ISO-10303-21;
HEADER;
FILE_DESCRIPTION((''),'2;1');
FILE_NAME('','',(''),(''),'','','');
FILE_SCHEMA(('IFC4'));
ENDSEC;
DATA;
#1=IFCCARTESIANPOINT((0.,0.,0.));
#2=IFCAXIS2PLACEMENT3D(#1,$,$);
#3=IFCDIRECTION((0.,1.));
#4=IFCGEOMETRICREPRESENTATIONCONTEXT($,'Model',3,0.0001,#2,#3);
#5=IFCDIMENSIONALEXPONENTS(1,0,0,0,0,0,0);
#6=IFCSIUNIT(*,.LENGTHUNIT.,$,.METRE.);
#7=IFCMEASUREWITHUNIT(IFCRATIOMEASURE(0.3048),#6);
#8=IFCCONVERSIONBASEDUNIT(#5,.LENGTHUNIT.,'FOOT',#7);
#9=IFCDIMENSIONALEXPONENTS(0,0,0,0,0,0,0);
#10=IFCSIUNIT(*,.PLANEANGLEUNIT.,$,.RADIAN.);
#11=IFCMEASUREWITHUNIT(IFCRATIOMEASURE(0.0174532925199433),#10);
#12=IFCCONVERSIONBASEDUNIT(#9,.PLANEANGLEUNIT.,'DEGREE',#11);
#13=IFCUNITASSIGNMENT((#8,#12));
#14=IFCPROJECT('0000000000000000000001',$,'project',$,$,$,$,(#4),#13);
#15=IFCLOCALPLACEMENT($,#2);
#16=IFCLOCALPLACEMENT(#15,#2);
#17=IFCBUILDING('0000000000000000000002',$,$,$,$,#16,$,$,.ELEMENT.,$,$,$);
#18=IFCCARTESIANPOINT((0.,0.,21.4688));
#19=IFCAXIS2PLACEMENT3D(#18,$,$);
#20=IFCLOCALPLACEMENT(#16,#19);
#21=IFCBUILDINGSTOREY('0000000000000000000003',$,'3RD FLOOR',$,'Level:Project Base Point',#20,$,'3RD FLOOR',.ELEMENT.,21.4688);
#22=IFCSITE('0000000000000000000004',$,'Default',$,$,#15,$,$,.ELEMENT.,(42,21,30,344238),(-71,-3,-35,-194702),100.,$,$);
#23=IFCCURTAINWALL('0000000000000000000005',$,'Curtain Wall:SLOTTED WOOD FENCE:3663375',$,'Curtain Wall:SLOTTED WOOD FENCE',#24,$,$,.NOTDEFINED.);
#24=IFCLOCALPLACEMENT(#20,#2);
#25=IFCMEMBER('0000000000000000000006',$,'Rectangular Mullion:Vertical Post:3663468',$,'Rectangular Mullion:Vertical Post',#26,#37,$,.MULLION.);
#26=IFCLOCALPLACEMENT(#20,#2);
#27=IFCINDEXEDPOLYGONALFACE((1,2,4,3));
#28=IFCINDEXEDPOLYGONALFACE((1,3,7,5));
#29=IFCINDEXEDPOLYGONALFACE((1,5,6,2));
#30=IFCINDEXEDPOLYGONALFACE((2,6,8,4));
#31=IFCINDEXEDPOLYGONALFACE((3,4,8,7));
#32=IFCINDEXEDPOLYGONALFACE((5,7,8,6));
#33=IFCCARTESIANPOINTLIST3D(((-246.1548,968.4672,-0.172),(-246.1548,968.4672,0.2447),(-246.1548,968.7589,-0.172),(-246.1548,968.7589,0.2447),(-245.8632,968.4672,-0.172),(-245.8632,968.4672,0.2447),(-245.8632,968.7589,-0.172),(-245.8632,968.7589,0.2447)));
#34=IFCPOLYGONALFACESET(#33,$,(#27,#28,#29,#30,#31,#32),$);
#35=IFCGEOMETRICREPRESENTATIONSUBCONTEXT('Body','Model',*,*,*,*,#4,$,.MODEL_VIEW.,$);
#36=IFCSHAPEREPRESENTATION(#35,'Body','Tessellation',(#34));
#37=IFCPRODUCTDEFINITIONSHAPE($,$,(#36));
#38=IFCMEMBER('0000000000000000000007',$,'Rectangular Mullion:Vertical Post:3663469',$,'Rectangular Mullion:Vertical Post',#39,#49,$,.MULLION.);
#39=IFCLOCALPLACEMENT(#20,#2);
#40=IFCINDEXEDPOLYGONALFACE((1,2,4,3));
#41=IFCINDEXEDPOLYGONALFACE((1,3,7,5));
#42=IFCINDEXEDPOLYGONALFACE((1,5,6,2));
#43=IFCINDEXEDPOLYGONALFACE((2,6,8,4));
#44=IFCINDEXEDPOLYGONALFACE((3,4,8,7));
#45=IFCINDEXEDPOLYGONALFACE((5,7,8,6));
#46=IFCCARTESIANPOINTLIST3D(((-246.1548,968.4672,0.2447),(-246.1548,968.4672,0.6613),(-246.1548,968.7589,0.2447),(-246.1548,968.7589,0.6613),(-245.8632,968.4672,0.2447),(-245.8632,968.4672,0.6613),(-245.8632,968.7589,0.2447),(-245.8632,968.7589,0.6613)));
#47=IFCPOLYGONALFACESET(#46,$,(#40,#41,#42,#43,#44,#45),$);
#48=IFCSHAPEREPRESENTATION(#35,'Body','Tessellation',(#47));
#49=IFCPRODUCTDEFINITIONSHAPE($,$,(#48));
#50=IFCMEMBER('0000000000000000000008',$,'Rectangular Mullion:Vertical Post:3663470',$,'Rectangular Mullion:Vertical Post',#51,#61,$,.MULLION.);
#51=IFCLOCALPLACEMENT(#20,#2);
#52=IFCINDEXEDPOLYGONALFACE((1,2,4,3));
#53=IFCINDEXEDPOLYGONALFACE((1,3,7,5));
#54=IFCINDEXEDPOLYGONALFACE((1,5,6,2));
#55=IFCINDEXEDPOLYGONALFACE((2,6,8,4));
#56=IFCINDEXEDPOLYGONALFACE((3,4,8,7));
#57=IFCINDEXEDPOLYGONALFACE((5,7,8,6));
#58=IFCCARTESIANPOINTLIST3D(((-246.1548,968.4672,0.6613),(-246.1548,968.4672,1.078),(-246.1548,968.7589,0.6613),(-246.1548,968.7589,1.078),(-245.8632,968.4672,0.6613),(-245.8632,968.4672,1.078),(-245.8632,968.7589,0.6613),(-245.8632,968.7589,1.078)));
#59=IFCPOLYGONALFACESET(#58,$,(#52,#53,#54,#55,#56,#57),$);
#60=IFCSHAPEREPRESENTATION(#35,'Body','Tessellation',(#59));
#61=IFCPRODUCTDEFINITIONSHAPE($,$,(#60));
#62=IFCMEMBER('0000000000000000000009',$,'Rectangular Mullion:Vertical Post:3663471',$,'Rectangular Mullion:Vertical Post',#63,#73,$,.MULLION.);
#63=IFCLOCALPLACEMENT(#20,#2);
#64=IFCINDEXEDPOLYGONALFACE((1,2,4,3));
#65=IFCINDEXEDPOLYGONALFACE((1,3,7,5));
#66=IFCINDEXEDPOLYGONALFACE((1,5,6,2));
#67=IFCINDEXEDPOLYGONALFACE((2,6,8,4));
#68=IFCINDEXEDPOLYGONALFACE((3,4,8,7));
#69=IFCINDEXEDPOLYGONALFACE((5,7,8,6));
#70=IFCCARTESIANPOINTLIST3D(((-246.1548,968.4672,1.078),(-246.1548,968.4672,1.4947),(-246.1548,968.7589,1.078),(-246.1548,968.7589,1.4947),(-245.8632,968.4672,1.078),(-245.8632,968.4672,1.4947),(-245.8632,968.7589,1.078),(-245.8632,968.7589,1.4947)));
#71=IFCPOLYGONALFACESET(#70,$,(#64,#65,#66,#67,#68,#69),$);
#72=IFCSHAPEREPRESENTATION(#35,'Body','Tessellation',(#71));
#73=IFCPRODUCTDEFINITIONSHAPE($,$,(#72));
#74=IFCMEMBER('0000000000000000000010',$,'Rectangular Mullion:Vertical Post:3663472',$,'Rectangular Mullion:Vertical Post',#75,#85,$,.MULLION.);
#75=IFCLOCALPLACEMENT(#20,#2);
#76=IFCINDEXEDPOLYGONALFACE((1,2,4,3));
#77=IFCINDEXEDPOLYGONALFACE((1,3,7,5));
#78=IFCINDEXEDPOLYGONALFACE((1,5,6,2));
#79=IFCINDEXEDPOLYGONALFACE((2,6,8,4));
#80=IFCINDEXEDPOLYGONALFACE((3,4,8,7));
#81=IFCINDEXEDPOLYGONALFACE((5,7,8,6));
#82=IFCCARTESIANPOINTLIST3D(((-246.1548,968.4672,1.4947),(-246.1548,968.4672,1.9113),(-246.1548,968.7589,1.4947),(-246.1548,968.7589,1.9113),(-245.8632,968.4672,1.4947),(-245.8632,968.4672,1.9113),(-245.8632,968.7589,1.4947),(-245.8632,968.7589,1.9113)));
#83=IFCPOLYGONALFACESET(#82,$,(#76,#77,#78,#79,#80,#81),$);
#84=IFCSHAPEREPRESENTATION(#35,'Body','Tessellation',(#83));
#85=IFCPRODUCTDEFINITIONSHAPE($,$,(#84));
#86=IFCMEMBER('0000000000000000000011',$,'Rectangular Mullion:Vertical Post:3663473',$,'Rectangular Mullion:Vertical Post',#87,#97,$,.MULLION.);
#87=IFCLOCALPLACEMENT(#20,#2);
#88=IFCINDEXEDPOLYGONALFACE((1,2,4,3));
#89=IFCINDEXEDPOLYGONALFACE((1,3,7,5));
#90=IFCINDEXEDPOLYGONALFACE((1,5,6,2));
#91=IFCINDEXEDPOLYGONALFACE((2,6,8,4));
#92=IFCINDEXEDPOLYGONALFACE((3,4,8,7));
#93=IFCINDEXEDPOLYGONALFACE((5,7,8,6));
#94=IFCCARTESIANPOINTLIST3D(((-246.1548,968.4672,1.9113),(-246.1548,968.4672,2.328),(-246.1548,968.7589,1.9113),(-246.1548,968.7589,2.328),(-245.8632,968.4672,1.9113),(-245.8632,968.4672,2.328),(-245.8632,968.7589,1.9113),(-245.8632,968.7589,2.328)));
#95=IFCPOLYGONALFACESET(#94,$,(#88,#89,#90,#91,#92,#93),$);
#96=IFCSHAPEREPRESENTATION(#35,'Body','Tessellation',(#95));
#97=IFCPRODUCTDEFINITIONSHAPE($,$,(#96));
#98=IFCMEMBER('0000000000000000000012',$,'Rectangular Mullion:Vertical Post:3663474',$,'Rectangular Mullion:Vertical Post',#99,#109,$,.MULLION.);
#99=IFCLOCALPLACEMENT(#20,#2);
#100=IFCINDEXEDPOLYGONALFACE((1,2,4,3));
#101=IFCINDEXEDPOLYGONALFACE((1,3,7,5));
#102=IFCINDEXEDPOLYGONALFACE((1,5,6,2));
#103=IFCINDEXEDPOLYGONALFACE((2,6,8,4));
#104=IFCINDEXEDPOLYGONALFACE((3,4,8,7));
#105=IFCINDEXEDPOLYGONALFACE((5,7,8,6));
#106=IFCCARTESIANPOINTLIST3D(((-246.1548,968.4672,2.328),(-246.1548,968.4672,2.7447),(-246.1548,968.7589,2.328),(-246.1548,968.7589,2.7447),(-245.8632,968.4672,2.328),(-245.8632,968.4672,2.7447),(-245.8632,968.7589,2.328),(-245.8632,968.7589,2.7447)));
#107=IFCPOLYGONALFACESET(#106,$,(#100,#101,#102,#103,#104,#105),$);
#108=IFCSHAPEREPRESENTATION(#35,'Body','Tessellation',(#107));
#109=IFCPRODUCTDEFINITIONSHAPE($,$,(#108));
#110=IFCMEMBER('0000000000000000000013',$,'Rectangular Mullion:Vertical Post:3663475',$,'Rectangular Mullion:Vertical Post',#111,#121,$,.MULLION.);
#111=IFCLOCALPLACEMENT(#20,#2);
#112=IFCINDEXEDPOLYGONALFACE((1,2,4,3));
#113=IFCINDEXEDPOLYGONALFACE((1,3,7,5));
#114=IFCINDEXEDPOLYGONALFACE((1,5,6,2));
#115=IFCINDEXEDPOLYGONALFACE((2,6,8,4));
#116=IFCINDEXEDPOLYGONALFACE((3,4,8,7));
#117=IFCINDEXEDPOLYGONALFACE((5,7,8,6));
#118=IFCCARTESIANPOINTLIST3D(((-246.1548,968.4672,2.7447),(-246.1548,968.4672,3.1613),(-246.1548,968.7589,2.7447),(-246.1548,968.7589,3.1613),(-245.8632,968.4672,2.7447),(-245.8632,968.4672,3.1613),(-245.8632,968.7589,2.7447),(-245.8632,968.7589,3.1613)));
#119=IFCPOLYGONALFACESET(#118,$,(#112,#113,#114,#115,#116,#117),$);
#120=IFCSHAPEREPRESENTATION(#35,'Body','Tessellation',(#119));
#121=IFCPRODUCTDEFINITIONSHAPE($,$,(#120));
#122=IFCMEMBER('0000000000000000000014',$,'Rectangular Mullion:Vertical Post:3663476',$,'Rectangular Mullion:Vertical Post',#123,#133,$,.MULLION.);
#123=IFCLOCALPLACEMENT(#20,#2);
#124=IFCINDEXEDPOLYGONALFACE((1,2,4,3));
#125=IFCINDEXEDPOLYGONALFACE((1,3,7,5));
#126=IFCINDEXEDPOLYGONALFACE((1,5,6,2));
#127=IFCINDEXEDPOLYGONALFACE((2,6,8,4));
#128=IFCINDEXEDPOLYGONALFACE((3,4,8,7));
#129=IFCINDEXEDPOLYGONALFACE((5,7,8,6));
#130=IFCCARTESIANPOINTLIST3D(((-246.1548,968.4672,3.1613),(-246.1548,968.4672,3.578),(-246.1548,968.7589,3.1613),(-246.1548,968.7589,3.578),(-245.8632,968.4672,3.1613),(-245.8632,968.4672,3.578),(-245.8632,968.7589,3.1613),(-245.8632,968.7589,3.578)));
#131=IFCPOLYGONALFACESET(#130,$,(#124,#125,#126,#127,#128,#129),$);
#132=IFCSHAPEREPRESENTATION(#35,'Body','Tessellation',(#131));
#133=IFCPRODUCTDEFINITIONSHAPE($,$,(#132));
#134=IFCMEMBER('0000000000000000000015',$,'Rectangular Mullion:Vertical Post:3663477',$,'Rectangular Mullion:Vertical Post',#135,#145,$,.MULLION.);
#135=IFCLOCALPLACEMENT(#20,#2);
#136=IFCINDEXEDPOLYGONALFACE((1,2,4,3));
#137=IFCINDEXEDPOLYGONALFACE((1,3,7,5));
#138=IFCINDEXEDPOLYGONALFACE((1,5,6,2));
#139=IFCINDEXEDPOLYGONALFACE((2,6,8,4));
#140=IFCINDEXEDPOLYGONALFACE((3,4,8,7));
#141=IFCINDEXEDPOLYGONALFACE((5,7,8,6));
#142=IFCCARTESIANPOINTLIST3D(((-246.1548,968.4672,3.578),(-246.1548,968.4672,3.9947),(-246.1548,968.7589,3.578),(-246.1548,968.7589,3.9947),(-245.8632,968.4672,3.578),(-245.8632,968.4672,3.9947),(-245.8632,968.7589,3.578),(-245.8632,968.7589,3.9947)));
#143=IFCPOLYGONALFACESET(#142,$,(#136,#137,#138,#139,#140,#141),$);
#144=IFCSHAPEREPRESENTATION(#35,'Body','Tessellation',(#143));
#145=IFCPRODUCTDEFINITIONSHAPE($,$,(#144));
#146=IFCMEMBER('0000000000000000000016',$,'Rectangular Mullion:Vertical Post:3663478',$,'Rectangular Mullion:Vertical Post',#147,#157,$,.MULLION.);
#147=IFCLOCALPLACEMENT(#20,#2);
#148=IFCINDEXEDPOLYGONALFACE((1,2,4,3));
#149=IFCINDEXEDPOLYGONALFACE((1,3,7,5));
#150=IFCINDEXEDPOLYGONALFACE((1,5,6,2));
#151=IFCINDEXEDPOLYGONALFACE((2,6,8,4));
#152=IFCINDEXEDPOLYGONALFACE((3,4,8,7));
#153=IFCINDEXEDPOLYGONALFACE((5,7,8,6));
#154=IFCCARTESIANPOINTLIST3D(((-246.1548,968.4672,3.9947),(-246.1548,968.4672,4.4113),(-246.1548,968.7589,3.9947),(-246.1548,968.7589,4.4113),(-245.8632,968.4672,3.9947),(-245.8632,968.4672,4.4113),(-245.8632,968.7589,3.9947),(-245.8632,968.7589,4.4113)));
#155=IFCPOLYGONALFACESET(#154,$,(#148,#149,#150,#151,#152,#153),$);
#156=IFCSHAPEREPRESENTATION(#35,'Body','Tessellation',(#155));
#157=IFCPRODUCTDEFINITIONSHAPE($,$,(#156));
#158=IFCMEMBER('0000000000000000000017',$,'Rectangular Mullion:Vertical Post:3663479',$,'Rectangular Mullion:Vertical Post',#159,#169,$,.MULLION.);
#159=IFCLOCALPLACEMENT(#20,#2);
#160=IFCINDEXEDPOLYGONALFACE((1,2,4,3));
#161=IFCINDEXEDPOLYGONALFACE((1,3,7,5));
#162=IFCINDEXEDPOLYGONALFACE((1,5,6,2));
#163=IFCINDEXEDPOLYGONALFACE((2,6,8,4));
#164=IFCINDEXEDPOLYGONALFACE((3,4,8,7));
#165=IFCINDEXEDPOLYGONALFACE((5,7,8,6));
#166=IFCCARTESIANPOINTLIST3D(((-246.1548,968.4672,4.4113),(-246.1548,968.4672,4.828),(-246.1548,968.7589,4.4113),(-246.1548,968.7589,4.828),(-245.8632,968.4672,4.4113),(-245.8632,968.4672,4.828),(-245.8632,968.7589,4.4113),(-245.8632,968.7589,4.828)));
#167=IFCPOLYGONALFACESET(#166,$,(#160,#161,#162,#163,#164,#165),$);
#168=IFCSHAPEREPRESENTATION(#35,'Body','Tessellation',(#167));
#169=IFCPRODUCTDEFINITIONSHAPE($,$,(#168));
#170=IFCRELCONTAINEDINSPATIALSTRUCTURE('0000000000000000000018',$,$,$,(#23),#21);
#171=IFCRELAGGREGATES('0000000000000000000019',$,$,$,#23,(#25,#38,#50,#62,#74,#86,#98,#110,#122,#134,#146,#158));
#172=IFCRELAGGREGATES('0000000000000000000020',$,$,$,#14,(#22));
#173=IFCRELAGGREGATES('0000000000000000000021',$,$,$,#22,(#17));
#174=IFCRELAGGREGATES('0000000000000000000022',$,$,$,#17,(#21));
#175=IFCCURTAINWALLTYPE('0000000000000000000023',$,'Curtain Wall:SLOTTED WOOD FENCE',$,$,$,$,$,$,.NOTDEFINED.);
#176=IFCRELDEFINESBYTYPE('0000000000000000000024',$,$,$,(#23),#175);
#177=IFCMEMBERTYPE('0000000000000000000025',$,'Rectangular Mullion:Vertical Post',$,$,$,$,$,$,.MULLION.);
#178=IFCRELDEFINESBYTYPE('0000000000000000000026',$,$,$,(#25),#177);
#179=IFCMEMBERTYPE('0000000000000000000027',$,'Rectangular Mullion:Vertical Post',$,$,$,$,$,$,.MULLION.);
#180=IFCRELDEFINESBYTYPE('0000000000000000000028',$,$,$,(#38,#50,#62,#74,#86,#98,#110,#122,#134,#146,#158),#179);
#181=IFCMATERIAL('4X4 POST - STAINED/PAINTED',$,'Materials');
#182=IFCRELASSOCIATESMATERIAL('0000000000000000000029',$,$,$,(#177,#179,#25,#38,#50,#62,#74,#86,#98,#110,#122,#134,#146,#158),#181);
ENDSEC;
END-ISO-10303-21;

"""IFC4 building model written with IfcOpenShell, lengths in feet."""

from ifc_helpers import new_model, entity, si_unit, converted_unit, direction, frame, origin, origin_2d_with_axis, place, context, subcontext, project, spatial, rectangle, extrude, source, transform, mapped, material, material_profile, profile_set, profile_usage, type_object, type_shapes, element, aggregate, save


model = new_model("IFC4")

# Units and contexts
model_context = context("Model", 3, precision=0.0001, world=origin(), true_north=direction((0.0, 1.0)))
body_context = subcontext(model_context, "Body", "Model", "MODEL_VIEW")
ifc_project = project(units=[converted_unit("LENGTHUNIT", "FOOT", entity("IfcRatioMeasure", 0.3048), si_unit("LENGTHUNIT", "METRE"), dimensions=[1, 0, 0, 0, 0, 0, 0]), converted_unit("PLANEANGLEUNIT", "DEGREE", entity("IfcRatioMeasure", 0.0174532925199433), si_unit("PLANEANGLEUNIT", "RADIAN"), dimensions=[0, 0, 0, 0, 0, 0, 0])], contexts=[model_context])

# Site, building, storey
site_placement = place(None, origin())
site = spatial("IfcSite", under=ifc_project, at=site_placement, Name="Default", CompositionType="ELEMENT", RefLatitude=(42, 21, 30, 344238), RefLongitude=(-71, -3, -35, -194702), RefElevation=100.0)
building_placement = place(site_placement, origin())
building = spatial("IfcBuilding", under=site, at=building_placement, CompositionType="ELEMENT")
storey_placement = place(building_placement, frame((0.0, 0.0, 21.4688)))
storey = spatial("IfcBuildingStorey", under=building, at=storey_placement, Name="3RD FLOOR", ObjectType="Level:Project Base Point", LongName="3RD FLOOR", CompositionType="ELEMENT", Elevation=21.4688)

# Curtain wall, members
curtain_wall_type = type_object("IfcCurtainWallType", Name="Curtain Wall:SLOTTED WOOD FENCE", PredefinedType="NOTDEFINED")
curtain_wall_placement = place(storey_placement, frame((0.0, 0.0, -21.4688)))
curtain_wall = element("IfcCurtainWall", 1, at=curtain_wall_placement, inside=storey, type_object=curtain_wall_type, Name="Curtain Wall:SLOTTED WOOD FENCE:3663375", ObjectType="Curtain Wall:SLOTTED WOOD FENCE", PredefinedType="NOTDEFINED")
ifc_material = material(Name="4X4 POST - STAINED/PAINTED", Category="Materials")
ifc_material_profile = material_profile(ifc_material, rectangle(XDim=0.2917, YDim=0.2917, at=origin_2d_with_axis()), Name="Vertical Post")
ifc_profile_set = profile_set([ifc_material_profile], Name="Vertical Post")
ifc_profile_usage_1 = profile_usage(ifc_profile_set)
member_type_1 = type_object("IfcMemberType", Name="Rectangular Mullion:Vertical Post", PredefinedType="MULLION", material=ifc_profile_set)
shared_shape_1 = source(origin(), body_context, "Body", "SweptSolid", [
    extrude(rectangle(XDim=0.2917, YDim=0.2917, at=origin_2d_with_axis()), frame((-0.1458, 0.2083, -0.4167), z_axis=(0.0, 0.0, 1.0), x_axis=(0.0, -1.0, 0.0)), (0.0, 0.0, 1.0), 0.4167),
])
type_shapes(member_type_1, [shared_shape_1])
member_1_placement = place(storey_placement, frame((-245.8007, 968.7589, 0.2447), z_axis=(0.0, 0.0, 1.0), x_axis=(0.0, 1.0, 0.0)))
member_1 = element("IfcMember", 2, at=member_1_placement, type_object=member_type_1, material=ifc_profile_usage_1, Name="Rectangular Mullion:Vertical Post:3663468", ObjectType="Rectangular Mullion:Vertical Post", PredefinedType="MULLION", context=body_context, shape_type="MappedRepresentation", body=[
    mapped(shared_shape_1, transform((0.0, 0.0, 0.0), scale=1.0)),
])
ifc_profile_usage_2 = profile_usage(ifc_profile_set)
member_type_2 = type_object("IfcMemberType", Name="Rectangular Mullion:Vertical Post", PredefinedType="MULLION", material=ifc_profile_set)
shared_shape_2 = source(origin(), body_context, "Body", "SweptSolid", [
    extrude(rectangle(XDim=0.2917, YDim=0.2917, at=origin_2d_with_axis()), frame((-0.1458, 0.2083, -0.4167), z_axis=(0.0, 0.0, 1.0), x_axis=(0.0, -1.0, 0.0)), (0.0, 0.0, 1.0), 0.4167),
])
type_shapes(member_type_2, [shared_shape_2])
member_2_placement = place(storey_placement, frame((-245.8007, 968.7589, 0.6613), z_axis=(0.0, 0.0, 1.0), x_axis=(0.0, 1.0, 0.0)))
member_2 = element("IfcMember", 3, at=member_2_placement, type_object=member_type_2, material=ifc_profile_usage_2, Name="Rectangular Mullion:Vertical Post:3663469", ObjectType="Rectangular Mullion:Vertical Post", PredefinedType="MULLION", context=body_context, shape_type="MappedRepresentation", body=[
    mapped(shared_shape_2, transform((0.0, 0.0, 0.0), scale=1.0)),
])
ifc_profile_usage_3 = profile_usage(ifc_profile_set)
member_3_placement = place(storey_placement, frame((-245.8007, 968.7589, 1.078), z_axis=(0.0, 0.0, 1.0), x_axis=(0.0, 1.0, 0.0)))
member_3 = element("IfcMember", 4, at=member_3_placement, type_object=member_type_2, material=ifc_profile_usage_3, Name="Rectangular Mullion:Vertical Post:3663470", ObjectType="Rectangular Mullion:Vertical Post", PredefinedType="MULLION", context=body_context, shape_type="MappedRepresentation", body=[
    mapped(shared_shape_2, transform((0.0, 0.0, 0.0), scale=1.0)),
])
ifc_profile_usage_4 = profile_usage(ifc_profile_set)
member_4_placement = place(storey_placement, frame((-245.8007, 968.7589, 1.4947), z_axis=(0.0, 0.0, 1.0), x_axis=(0.0, 1.0, 0.0)))
member_4 = element("IfcMember", 5, at=member_4_placement, type_object=member_type_2, material=ifc_profile_usage_4, Name="Rectangular Mullion:Vertical Post:3663471", ObjectType="Rectangular Mullion:Vertical Post", PredefinedType="MULLION", context=body_context, shape_type="MappedRepresentation", body=[
    mapped(shared_shape_2, transform((0.0, 0.0, 0.0), scale=1.0)),
])
ifc_profile_usage_5 = profile_usage(ifc_profile_set)
member_5_placement = place(storey_placement, frame((-245.8007, 968.7589, 1.9113), z_axis=(0.0, 0.0, 1.0), x_axis=(0.0, 1.0, 0.0)))
member_5 = element("IfcMember", 6, at=member_5_placement, type_object=member_type_2, material=ifc_profile_usage_5, Name="Rectangular Mullion:Vertical Post:3663472", ObjectType="Rectangular Mullion:Vertical Post", PredefinedType="MULLION", context=body_context, shape_type="MappedRepresentation", body=[
    mapped(shared_shape_2, transform((0.0, 0.0, 0.0), scale=1.0)),
])
ifc_profile_usage_6 = profile_usage(ifc_profile_set)
member_6_placement = place(storey_placement, frame((-245.8007, 968.7589, 2.328), z_axis=(0.0, 0.0, 1.0), x_axis=(0.0, 1.0, 0.0)))
member_6 = element("IfcMember", 7, at=member_6_placement, type_object=member_type_2, material=ifc_profile_usage_6, Name="Rectangular Mullion:Vertical Post:3663473", ObjectType="Rectangular Mullion:Vertical Post", PredefinedType="MULLION", context=body_context, shape_type="MappedRepresentation", body=[
    mapped(shared_shape_2, transform((0.0, 0.0, 0.0), scale=1.0)),
])
ifc_profile_usage_7 = profile_usage(ifc_profile_set)
member_7_placement = place(storey_placement, frame((-245.8007, 968.7589, 2.7447), z_axis=(0.0, 0.0, 1.0), x_axis=(0.0, 1.0, 0.0)))
member_7 = element("IfcMember", 8, at=member_7_placement, type_object=member_type_2, material=ifc_profile_usage_7, Name="Rectangular Mullion:Vertical Post:3663474", ObjectType="Rectangular Mullion:Vertical Post", PredefinedType="MULLION", context=body_context, shape_type="MappedRepresentation", body=[
    mapped(shared_shape_2, transform((0.0, 0.0, 0.0), scale=1.0)),
])
ifc_profile_usage_8 = profile_usage(ifc_profile_set)
member_8_placement = place(storey_placement, frame((-245.8007, 968.7589, 3.1613), z_axis=(0.0, 0.0, 1.0), x_axis=(0.0, 1.0, 0.0)))
member_8 = element("IfcMember", 9, at=member_8_placement, type_object=member_type_2, material=ifc_profile_usage_8, Name="Rectangular Mullion:Vertical Post:3663475", ObjectType="Rectangular Mullion:Vertical Post", PredefinedType="MULLION", context=body_context, shape_type="MappedRepresentation", body=[
    mapped(shared_shape_2, transform((0.0, 0.0, 0.0), scale=1.0)),
])
ifc_profile_usage_9 = profile_usage(ifc_profile_set)
member_9_placement = place(storey_placement, frame((-245.8007, 968.7589, 3.578), z_axis=(0.0, 0.0, 1.0), x_axis=(0.0, 1.0, 0.0)))
member_9 = element("IfcMember", 10, at=member_9_placement, type_object=member_type_2, material=ifc_profile_usage_9, Name="Rectangular Mullion:Vertical Post:3663476", ObjectType="Rectangular Mullion:Vertical Post", PredefinedType="MULLION", context=body_context, shape_type="MappedRepresentation", body=[
    mapped(shared_shape_2, transform((0.0, 0.0, 0.0), scale=1.0)),
])
ifc_profile_usage_10 = profile_usage(ifc_profile_set)
member_10_placement = place(storey_placement, frame((-245.8007, 968.7589, 3.9947), z_axis=(0.0, 0.0, 1.0), x_axis=(0.0, 1.0, 0.0)))
member_10 = element("IfcMember", 11, at=member_10_placement, type_object=member_type_2, material=ifc_profile_usage_10, Name="Rectangular Mullion:Vertical Post:3663477", ObjectType="Rectangular Mullion:Vertical Post", PredefinedType="MULLION", context=body_context, shape_type="MappedRepresentation", body=[
    mapped(shared_shape_2, transform((0.0, 0.0, 0.0), scale=1.0)),
])
ifc_profile_usage_11 = profile_usage(ifc_profile_set)
member_11_placement = place(storey_placement, frame((-245.8007, 968.7589, 4.4113), z_axis=(0.0, 0.0, 1.0), x_axis=(0.0, 1.0, 0.0)))
member_11 = element("IfcMember", 12, at=member_11_placement, type_object=member_type_2, material=ifc_profile_usage_11, Name="Rectangular Mullion:Vertical Post:3663478", ObjectType="Rectangular Mullion:Vertical Post", PredefinedType="MULLION", context=body_context, shape_type="MappedRepresentation", body=[
    mapped(shared_shape_2, transform((0.0, 0.0, 0.0), scale=1.0)),
])
ifc_profile_usage_12 = profile_usage(ifc_profile_set)
member_12_placement = place(storey_placement, frame((-245.8007, 968.7589, 4.828), z_axis=(0.0, 0.0, 1.0), x_axis=(0.0, 1.0, 0.0)))
member_12 = element("IfcMember", 13, at=member_12_placement, type_object=member_type_2, material=ifc_profile_usage_12, Name="Rectangular Mullion:Vertical Post:3663479", ObjectType="Rectangular Mullion:Vertical Post", PredefinedType="MULLION", context=body_context, shape_type="MappedRepresentation", body=[
    mapped(shared_shape_2, transform((0.0, 0.0, 0.0), scale=1.0)),
])
aggregate(curtain_wall, [member_1, member_2, member_3, member_4, member_5, member_6, member_7, member_8, member_9, member_10, member_11, member_12])

save(model, "model.ifc")
